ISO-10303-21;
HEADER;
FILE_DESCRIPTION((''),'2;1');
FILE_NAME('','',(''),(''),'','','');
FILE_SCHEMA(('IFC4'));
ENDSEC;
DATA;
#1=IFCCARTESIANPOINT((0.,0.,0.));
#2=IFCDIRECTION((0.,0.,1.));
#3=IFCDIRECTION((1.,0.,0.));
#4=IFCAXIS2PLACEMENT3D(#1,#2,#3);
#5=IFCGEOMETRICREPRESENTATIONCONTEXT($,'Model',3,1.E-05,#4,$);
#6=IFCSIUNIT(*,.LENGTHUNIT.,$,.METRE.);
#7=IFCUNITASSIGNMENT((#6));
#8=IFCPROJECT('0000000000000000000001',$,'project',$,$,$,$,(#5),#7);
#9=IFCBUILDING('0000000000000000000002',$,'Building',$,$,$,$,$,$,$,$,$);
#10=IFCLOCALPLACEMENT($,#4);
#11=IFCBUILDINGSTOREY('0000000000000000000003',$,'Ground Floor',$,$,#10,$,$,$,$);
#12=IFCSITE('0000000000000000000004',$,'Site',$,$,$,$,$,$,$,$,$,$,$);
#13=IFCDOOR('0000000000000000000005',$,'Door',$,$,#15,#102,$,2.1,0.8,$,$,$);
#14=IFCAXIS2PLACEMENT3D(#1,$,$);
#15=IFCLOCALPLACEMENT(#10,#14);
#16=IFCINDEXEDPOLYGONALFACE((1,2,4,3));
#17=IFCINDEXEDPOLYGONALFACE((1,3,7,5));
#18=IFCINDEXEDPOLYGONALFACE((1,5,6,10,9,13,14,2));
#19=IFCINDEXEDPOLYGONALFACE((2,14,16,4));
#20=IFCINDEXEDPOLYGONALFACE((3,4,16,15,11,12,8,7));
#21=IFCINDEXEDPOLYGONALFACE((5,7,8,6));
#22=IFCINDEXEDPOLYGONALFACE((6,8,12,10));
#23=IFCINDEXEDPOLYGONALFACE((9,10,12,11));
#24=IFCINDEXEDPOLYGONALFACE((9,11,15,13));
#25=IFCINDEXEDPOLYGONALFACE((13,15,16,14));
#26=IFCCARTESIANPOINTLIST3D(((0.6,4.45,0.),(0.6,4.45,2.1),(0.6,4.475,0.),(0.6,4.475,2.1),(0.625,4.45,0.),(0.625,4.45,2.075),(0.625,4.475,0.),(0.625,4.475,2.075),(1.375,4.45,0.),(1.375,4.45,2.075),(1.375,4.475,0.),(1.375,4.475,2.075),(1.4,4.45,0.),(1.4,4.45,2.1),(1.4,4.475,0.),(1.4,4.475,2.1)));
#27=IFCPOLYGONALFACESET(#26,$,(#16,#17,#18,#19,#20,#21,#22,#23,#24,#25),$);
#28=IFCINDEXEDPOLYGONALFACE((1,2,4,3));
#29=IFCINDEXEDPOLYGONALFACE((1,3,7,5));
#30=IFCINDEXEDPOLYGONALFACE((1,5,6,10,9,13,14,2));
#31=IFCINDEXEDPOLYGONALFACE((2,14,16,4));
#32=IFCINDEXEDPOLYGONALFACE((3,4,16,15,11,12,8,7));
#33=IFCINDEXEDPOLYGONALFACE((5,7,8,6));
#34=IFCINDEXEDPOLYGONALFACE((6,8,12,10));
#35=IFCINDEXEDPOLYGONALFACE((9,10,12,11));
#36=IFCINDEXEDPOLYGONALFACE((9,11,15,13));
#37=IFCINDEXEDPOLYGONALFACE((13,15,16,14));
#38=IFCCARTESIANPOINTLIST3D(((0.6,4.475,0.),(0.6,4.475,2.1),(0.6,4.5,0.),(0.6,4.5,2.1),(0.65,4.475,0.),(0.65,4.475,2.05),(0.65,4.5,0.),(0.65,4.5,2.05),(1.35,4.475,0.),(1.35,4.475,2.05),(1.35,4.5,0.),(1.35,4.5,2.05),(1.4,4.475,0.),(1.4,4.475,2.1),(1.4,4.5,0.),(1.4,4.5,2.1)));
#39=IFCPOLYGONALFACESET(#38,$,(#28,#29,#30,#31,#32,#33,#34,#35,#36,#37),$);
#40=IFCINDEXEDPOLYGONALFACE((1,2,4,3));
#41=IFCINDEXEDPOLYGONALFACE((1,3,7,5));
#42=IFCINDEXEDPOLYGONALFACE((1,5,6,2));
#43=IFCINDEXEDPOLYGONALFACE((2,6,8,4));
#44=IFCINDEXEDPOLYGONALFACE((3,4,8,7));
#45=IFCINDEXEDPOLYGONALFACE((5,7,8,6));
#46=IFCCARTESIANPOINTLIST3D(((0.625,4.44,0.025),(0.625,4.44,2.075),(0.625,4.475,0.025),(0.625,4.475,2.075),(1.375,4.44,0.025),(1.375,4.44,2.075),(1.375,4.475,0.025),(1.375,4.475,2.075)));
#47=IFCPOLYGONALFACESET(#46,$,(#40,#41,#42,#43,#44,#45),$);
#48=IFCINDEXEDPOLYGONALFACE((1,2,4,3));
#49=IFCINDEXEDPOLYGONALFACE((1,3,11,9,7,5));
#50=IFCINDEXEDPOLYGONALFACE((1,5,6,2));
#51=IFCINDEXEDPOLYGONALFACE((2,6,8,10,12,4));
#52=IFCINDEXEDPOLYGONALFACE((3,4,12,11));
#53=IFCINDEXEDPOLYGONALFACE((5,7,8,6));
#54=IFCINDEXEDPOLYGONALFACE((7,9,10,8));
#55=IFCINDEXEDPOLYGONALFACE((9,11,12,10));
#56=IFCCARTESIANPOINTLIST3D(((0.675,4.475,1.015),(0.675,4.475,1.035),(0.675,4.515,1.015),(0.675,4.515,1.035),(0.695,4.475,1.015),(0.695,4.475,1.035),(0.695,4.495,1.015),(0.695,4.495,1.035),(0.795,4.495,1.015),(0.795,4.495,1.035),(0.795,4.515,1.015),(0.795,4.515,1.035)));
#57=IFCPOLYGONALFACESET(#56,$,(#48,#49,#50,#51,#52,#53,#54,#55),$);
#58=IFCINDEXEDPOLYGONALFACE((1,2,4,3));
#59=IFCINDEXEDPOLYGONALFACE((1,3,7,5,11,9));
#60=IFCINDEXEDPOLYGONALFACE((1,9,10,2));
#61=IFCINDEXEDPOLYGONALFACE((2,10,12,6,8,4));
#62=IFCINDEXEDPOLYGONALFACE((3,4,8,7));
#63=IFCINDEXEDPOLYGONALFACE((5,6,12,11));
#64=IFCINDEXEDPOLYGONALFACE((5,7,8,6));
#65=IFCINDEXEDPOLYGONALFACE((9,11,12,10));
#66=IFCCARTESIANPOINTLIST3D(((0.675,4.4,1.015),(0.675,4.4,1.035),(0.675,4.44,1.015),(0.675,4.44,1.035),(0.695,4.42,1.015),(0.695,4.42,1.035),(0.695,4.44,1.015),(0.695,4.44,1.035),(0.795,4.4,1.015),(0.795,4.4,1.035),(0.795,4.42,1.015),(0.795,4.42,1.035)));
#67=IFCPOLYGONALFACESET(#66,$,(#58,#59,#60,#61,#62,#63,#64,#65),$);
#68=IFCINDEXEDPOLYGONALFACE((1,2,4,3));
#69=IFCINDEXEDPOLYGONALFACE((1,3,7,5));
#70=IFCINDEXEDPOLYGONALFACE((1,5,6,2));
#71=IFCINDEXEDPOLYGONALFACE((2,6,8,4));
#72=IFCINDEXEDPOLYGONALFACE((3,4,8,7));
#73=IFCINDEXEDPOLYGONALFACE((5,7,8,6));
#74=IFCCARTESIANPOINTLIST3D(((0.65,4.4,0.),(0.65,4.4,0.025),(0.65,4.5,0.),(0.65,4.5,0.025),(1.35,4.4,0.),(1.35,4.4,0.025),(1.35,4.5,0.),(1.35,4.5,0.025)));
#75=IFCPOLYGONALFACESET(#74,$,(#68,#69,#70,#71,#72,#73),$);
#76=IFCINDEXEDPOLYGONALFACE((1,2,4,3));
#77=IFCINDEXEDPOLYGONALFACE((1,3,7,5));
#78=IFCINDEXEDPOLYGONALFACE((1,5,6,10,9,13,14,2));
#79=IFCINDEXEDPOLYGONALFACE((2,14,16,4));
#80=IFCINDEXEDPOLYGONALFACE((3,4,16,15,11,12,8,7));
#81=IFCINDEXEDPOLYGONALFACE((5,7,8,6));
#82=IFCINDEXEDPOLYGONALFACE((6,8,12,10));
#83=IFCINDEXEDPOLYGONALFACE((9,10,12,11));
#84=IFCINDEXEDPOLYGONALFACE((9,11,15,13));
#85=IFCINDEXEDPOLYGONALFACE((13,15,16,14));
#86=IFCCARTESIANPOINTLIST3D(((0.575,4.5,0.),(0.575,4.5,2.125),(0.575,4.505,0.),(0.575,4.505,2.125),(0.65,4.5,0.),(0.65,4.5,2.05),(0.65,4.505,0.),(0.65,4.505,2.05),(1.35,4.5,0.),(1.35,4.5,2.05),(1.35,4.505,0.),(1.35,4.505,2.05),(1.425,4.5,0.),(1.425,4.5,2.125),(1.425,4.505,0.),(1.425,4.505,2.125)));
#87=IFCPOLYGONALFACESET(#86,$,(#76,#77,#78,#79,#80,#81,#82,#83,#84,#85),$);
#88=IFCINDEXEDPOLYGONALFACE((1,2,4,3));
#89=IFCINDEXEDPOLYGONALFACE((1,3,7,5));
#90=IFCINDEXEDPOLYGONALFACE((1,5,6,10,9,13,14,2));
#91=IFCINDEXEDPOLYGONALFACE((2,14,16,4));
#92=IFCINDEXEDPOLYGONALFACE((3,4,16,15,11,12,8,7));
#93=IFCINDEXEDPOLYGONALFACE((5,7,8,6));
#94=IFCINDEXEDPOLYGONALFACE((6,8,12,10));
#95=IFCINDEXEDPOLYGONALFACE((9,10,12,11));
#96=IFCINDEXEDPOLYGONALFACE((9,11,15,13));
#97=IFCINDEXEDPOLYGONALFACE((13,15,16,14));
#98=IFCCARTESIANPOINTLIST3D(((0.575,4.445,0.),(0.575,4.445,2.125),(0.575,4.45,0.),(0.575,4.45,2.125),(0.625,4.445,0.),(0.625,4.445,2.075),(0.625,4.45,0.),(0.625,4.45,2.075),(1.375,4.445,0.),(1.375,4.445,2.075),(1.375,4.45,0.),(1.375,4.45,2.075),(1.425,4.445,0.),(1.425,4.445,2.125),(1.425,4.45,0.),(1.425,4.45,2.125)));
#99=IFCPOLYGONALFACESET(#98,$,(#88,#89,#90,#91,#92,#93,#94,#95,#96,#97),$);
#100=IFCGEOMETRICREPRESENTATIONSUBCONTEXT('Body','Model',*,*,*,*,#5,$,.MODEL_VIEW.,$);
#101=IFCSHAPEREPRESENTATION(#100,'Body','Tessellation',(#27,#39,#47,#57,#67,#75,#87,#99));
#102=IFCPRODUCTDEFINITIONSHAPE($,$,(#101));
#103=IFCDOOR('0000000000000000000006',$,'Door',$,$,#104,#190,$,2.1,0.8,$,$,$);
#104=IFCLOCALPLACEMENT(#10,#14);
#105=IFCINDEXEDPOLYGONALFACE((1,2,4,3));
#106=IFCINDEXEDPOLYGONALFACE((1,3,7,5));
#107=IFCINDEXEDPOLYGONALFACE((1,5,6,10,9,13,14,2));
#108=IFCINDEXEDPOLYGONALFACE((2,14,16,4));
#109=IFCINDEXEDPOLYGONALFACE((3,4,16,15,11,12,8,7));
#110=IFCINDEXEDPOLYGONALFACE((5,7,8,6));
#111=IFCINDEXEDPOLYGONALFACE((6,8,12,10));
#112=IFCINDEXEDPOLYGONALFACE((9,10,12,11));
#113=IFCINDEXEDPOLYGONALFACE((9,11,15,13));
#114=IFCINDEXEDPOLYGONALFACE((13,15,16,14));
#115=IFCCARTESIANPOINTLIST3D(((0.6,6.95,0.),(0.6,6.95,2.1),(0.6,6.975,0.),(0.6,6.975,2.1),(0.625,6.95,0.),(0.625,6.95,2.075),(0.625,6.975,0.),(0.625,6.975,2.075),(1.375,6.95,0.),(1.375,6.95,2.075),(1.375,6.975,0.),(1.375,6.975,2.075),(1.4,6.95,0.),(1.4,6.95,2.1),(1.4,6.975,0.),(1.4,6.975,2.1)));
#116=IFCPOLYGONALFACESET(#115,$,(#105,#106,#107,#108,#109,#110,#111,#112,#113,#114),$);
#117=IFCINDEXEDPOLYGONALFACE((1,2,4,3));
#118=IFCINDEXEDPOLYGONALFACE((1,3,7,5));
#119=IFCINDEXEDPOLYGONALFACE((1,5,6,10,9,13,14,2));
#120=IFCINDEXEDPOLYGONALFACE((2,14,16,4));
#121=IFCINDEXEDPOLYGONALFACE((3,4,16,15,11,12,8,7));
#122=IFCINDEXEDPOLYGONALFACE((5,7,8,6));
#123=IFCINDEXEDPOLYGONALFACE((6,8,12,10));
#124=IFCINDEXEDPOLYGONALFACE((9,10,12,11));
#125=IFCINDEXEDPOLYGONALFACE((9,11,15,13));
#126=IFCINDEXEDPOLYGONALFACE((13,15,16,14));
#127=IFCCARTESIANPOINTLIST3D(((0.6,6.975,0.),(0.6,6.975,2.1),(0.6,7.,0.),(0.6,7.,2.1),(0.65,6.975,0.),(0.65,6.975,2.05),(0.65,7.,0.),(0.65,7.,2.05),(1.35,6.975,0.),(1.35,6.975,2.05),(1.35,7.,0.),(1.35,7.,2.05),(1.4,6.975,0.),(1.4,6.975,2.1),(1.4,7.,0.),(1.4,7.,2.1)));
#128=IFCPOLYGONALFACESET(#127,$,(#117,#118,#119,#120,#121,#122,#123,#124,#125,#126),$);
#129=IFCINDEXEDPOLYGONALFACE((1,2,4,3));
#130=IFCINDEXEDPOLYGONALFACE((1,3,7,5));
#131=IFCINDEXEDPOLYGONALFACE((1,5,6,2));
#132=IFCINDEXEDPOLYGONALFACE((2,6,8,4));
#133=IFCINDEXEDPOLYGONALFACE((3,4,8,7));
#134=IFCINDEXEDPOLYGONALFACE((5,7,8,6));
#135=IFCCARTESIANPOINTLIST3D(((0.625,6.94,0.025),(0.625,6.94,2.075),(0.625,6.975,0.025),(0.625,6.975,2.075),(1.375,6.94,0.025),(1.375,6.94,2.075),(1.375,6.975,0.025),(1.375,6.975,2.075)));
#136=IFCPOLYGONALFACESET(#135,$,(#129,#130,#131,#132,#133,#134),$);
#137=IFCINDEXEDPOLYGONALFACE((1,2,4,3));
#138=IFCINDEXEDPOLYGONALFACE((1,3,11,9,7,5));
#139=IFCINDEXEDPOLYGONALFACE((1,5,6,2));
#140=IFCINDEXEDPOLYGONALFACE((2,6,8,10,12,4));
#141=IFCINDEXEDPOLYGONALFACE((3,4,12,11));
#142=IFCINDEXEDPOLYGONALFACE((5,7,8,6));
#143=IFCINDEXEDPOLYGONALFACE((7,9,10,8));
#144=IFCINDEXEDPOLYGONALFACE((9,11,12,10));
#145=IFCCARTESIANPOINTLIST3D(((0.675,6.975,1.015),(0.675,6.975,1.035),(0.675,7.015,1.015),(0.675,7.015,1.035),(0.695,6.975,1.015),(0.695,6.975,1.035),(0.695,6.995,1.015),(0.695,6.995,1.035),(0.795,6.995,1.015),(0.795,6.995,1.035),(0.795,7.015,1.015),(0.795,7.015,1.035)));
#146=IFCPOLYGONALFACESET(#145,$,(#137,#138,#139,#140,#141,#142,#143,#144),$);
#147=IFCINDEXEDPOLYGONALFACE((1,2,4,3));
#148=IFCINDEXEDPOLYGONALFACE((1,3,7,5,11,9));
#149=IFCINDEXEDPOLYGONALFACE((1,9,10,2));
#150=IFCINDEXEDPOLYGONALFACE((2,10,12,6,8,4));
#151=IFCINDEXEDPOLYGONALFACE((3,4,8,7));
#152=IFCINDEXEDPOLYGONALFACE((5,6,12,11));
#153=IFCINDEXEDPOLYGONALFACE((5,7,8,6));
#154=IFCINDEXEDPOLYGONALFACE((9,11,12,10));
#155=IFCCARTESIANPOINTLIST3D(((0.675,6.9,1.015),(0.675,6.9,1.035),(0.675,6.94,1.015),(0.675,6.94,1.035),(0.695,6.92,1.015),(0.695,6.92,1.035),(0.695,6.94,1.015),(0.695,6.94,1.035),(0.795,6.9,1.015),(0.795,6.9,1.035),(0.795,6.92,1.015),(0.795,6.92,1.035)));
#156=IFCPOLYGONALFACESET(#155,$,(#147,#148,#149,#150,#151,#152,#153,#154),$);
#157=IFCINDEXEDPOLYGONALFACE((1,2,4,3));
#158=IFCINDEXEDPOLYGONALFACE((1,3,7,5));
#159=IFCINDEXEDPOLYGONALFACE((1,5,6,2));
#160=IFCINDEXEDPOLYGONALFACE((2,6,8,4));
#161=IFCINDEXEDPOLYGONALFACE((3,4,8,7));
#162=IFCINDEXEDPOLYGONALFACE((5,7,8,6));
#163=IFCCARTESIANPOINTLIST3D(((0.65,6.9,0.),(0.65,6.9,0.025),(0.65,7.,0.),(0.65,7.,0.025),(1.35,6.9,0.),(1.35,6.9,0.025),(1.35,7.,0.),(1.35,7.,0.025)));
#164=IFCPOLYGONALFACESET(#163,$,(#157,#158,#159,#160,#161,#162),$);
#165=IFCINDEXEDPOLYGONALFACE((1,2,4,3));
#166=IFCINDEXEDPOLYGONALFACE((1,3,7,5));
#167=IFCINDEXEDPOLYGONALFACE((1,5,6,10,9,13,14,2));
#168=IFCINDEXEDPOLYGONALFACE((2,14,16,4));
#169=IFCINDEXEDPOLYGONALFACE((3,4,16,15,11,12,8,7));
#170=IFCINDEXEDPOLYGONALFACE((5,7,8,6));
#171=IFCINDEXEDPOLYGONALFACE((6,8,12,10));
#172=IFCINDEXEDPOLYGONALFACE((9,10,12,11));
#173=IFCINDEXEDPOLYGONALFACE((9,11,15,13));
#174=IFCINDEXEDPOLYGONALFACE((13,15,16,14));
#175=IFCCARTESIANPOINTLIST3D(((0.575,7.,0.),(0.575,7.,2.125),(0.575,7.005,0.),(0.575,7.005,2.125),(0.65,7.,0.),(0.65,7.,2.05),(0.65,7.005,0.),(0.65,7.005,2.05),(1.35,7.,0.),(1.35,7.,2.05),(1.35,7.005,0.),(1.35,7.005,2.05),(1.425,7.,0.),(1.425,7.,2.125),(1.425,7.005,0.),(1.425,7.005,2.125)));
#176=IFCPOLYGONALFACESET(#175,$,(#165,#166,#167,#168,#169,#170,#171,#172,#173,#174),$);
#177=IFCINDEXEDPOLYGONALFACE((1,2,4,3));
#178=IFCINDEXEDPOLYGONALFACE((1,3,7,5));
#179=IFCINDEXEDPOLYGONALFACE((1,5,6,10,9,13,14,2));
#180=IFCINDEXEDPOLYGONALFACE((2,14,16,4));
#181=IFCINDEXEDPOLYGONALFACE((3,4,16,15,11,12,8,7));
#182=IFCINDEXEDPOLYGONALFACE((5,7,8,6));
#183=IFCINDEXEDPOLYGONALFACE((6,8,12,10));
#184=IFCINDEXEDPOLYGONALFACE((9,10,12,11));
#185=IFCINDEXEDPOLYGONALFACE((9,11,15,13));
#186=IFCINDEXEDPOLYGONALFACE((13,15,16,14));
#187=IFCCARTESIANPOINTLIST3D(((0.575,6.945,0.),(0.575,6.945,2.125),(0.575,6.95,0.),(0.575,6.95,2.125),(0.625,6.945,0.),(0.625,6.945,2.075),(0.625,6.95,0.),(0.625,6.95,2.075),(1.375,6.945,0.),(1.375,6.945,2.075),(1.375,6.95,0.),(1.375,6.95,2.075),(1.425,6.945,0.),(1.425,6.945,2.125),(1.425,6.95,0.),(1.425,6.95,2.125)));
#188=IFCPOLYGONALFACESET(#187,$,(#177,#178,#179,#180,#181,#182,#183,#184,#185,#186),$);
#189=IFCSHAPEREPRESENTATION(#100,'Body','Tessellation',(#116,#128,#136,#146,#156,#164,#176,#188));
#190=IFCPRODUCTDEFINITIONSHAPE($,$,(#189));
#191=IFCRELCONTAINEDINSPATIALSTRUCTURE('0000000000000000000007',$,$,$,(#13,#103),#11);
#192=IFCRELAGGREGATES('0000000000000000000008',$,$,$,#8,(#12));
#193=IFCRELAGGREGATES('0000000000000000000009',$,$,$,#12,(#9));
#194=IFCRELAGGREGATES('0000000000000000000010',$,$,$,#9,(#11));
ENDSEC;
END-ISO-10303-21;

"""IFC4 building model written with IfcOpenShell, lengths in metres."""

from ifc_helpers import new_model, si_unit, frame, origin_with_axes, place, context, subcontext, project, spatial, line, indexed_curve, outline, extrude, element, save


model = new_model("IFC4")

# Units and contexts
model_context = context("Model", 3, precision=1e-05, world=origin_with_axes())
body_context = subcontext(model_context, "Body", "Model", "MODEL_VIEW")
ifc_project = project(units=[si_unit("LENGTHUNIT", "METRE")], contexts=[model_context])

# Site, building, storey
site = spatial("IfcSite", under=ifc_project, Name="Site")
building = spatial("IfcBuilding", under=site, Name="Building")
storey_placement = place(None, origin_with_axes())
storey = spatial("IfcBuildingStorey", under=building, at=storey_placement, Name="Ground Floor")

# Doors
door_1_placement = place(storey_placement, frame((1.4, 4.5, 0.0), z_axis=(0.0, 0.0, 1.0), x_axis=(-1.0, 0.0, 0.0)))
element("IfcDoor", 1, at=door_1_placement, inside=storey, Name="Door", OverallHeight=2.1, OverallWidth=0.8, context=body_context, shape_type="SweptSolid", body=[
    extrude(outline(indexed_curve([(0.0, 0.0), (0.0, 2.1), (0.8, 2.1), (0.8, 0.0), (0.775, 0.0), (0.775, 2.075), (0.025, 2.075), (0.025, 0.0)], segments=[line(1, 2, 3, 4, 5, 6, 7, 8, 1)])), frame((0.0, 0.025, 0.0), z_axis=(0.0, -1.0, 0.0), x_axis=(1.0, 0.0, 0.0)), (0.0, 0.0, -1.0), 0.025),
    extrude(outline(indexed_curve([(0.0, 0.0), (0.0, 2.1), (0.8, 2.1), (0.8, 0.0), (0.75, 0.0), (0.75, 2.05), (0.05, 2.05), (0.05, 0.0)], segments=[line(1, 2, 3, 4, 5, 6, 7, 8, 1)])), frame((0.0, 0.0, 0.0), z_axis=(0.0, -1.0, 0.0), x_axis=(1.0, 0.0, 0.0)), (0.0, 0.0, -1.0), 0.025),
    extrude(outline(indexed_curve([(0.0, 0.0), (0.75, 0.0), (0.75, 0.035), (0.0, 0.035)], segments=[line(1, 2, 3, 4, 1)])), frame((0.025, 0.025, 0.025), z_axis=(0.0, 0.0, 1.0), x_axis=(1.0, 0.0, 0.0)), (0.0, 0.0, 1.0), 2.05),
    extrude(outline(indexed_curve([(0.0, 0.0), (0.0, -0.04), (-0.12, -0.04), (-0.12, -0.02), (-0.02, -0.02), (-0.02, 0.0)], segments=[line(1, 2, 3, 4, 5, 6, 1)])), frame((0.725, 0.025, 1.015), z_axis=(0.0, 0.0, 1.0), x_axis=(1.0, 0.0, 0.0)), (0.0, 0.0, 1.0), 0.02),
    extrude(outline(indexed_curve([(0.0, 0.0), (0.0, 0.04), (-0.12, 0.04), (-0.12, 0.02), (-0.02, 0.02), (-0.02, 0.0)], segments=[line(1, 2, 3, 4, 5, 6, 1)])), frame((0.725, 0.06, 1.015), z_axis=(0.0, 0.0, 1.0), x_axis=(1.0, 0.0, 0.0)), (0.0, 0.0, 1.0), 0.02),
    extrude(outline(indexed_curve([(0.0, 0.0), (0.7, 0.0), (0.7, 0.1), (0.0, 0.1)], segments=[line(1, 2, 3, 4, 1)])), frame((0.05, 0.0, 0.0), z_axis=(0.0, 0.0, 1.0), x_axis=(1.0, 0.0, 0.0)), (0.0, 0.0, 1.0), 0.025),
    extrude(outline(indexed_curve([(0.0, 0.0), (0.0, 2.125), (0.85, 2.125), (0.85, 0.0), (0.775, 0.0), (0.775, 2.05), (0.075, 2.05), (0.075, 0.0)], segments=[line(1, 2, 3, 4, 5, 6, 7, 8, 1)])), frame((-0.025, -0.005, 0.0), z_axis=(0.0, -1.0, 0.0), x_axis=(1.0, 0.0, 0.0)), (0.0, 0.0, -1.0), 0.005),
    extrude(outline(indexed_curve([(0.0, 0.0), (0.0, 2.125), (0.85, 2.125), (0.85, 0.0), (0.8, 0.0), (0.8, 2.075), (0.05, 2.075), (0.05, 0.0)], segments=[line(1, 2, 3, 4, 5, 6, 7, 8, 1)])), frame((-0.025, 0.05, 0.0), z_axis=(0.0, -1.0, 0.0), x_axis=(1.0, 0.0, 0.0)), (0.0, 0.0, -1.0), 0.005),
])
door_2_placement = place(storey_placement, frame((1.4, 7.0, 0.0), z_axis=(0.0, 0.0, 1.0), x_axis=(-1.0, 0.0, 0.0)))
element("IfcDoor", 2, at=door_2_placement, inside=storey, Name="Door", OverallHeight=2.1, OverallWidth=0.8, context=body_context, shape_type="SweptSolid", body=[
    extrude(outline(indexed_curve([(0.0, 0.0), (0.0, 2.1), (0.8, 2.1), (0.8, 0.0), (0.775, 0.0), (0.775, 2.075), (0.025, 2.075), (0.025, 0.0)], segments=[line(1, 2, 3, 4, 5, 6, 7, 8, 1)])), frame((0.0, 0.025, 0.0), z_axis=(0.0, -1.0, 0.0), x_axis=(1.0, 0.0, 0.0)), (0.0, 0.0, -1.0), 0.025),
    extrude(outline(indexed_curve([(0.0, 0.0), (0.0, 2.1), (0.8, 2.1), (0.8, 0.0), (0.75, 0.0), (0.75, 2.05), (0.05, 2.05), (0.05, 0.0)], segments=[line(1, 2, 3, 4, 5, 6, 7, 8, 1)])), frame((0.0, 0.0, 0.0), z_axis=(0.0, -1.0, 0.0), x_axis=(1.0, 0.0, 0.0)), (0.0, 0.0, -1.0), 0.025),
    extrude(outline(indexed_curve([(0.0, 0.0), (0.75, 0.0), (0.75, 0.035), (0.0, 0.035)], segments=[line(1, 2, 3, 4, 1)])), frame((0.025, 0.025, 0.025), z_axis=(0.0, 0.0, 1.0), x_axis=(1.0, 0.0, 0.0)), (0.0, 0.0, 1.0), 2.05),
    extrude(outline(indexed_curve([(0.0, 0.0), (0.0, -0.04), (-0.12, -0.04), (-0.12, -0.02), (-0.02, -0.02), (-0.02, 0.0)], segments=[line(1, 2, 3, 4, 5, 6, 1)])), frame((0.725, 0.025, 1.015), z_axis=(0.0, 0.0, 1.0), x_axis=(1.0, 0.0, 0.0)), (0.0, 0.0, 1.0), 0.02),
    extrude(outline(indexed_curve([(0.0, 0.0), (0.0, 0.04), (-0.12, 0.04), (-0.12, 0.02), (-0.02, 0.02), (-0.02, 0.0)], segments=[line(1, 2, 3, 4, 5, 6, 1)])), frame((0.725, 0.06, 1.015), z_axis=(0.0, 0.0, 1.0), x_axis=(1.0, 0.0, 0.0)), (0.0, 0.0, 1.0), 0.02),
    extrude(outline(indexed_curve([(0.0, 0.0), (0.7, 0.0), (0.7, 0.1), (0.0, 0.1)], segments=[line(1, 2, 3, 4, 1)])), frame((0.05, 0.0, 0.0), z_axis=(0.0, 0.0, 1.0), x_axis=(1.0, 0.0, 0.0)), (0.0, 0.0, 1.0), 0.025),
    extrude(outline(indexed_curve([(0.0, 0.0), (0.0, 2.125), (0.85, 2.125), (0.85, 0.0), (0.775, 0.0), (0.775, 2.05), (0.075, 2.05), (0.075, 0.0)], segments=[line(1, 2, 3, 4, 5, 6, 7, 8, 1)])), frame((-0.025, -0.005, 0.0), z_axis=(0.0, -1.0, 0.0), x_axis=(1.0, 0.0, 0.0)), (0.0, 0.0, -1.0), 0.005),
    extrude(outline(indexed_curve([(0.0, 0.0), (0.0, 2.125), (0.85, 2.125), (0.85, 0.0), (0.8, 0.0), (0.8, 2.075), (0.05, 2.075), (0.05, 0.0)], segments=[line(1, 2, 3, 4, 5, 6, 7, 8, 1)])), frame((-0.025, 0.05, 0.0), z_axis=(0.0, -1.0, 0.0), x_axis=(1.0, 0.0, 0.0)), (0.0, 0.0, -1.0), 0.005),
])

save(model, "model.ifc")
